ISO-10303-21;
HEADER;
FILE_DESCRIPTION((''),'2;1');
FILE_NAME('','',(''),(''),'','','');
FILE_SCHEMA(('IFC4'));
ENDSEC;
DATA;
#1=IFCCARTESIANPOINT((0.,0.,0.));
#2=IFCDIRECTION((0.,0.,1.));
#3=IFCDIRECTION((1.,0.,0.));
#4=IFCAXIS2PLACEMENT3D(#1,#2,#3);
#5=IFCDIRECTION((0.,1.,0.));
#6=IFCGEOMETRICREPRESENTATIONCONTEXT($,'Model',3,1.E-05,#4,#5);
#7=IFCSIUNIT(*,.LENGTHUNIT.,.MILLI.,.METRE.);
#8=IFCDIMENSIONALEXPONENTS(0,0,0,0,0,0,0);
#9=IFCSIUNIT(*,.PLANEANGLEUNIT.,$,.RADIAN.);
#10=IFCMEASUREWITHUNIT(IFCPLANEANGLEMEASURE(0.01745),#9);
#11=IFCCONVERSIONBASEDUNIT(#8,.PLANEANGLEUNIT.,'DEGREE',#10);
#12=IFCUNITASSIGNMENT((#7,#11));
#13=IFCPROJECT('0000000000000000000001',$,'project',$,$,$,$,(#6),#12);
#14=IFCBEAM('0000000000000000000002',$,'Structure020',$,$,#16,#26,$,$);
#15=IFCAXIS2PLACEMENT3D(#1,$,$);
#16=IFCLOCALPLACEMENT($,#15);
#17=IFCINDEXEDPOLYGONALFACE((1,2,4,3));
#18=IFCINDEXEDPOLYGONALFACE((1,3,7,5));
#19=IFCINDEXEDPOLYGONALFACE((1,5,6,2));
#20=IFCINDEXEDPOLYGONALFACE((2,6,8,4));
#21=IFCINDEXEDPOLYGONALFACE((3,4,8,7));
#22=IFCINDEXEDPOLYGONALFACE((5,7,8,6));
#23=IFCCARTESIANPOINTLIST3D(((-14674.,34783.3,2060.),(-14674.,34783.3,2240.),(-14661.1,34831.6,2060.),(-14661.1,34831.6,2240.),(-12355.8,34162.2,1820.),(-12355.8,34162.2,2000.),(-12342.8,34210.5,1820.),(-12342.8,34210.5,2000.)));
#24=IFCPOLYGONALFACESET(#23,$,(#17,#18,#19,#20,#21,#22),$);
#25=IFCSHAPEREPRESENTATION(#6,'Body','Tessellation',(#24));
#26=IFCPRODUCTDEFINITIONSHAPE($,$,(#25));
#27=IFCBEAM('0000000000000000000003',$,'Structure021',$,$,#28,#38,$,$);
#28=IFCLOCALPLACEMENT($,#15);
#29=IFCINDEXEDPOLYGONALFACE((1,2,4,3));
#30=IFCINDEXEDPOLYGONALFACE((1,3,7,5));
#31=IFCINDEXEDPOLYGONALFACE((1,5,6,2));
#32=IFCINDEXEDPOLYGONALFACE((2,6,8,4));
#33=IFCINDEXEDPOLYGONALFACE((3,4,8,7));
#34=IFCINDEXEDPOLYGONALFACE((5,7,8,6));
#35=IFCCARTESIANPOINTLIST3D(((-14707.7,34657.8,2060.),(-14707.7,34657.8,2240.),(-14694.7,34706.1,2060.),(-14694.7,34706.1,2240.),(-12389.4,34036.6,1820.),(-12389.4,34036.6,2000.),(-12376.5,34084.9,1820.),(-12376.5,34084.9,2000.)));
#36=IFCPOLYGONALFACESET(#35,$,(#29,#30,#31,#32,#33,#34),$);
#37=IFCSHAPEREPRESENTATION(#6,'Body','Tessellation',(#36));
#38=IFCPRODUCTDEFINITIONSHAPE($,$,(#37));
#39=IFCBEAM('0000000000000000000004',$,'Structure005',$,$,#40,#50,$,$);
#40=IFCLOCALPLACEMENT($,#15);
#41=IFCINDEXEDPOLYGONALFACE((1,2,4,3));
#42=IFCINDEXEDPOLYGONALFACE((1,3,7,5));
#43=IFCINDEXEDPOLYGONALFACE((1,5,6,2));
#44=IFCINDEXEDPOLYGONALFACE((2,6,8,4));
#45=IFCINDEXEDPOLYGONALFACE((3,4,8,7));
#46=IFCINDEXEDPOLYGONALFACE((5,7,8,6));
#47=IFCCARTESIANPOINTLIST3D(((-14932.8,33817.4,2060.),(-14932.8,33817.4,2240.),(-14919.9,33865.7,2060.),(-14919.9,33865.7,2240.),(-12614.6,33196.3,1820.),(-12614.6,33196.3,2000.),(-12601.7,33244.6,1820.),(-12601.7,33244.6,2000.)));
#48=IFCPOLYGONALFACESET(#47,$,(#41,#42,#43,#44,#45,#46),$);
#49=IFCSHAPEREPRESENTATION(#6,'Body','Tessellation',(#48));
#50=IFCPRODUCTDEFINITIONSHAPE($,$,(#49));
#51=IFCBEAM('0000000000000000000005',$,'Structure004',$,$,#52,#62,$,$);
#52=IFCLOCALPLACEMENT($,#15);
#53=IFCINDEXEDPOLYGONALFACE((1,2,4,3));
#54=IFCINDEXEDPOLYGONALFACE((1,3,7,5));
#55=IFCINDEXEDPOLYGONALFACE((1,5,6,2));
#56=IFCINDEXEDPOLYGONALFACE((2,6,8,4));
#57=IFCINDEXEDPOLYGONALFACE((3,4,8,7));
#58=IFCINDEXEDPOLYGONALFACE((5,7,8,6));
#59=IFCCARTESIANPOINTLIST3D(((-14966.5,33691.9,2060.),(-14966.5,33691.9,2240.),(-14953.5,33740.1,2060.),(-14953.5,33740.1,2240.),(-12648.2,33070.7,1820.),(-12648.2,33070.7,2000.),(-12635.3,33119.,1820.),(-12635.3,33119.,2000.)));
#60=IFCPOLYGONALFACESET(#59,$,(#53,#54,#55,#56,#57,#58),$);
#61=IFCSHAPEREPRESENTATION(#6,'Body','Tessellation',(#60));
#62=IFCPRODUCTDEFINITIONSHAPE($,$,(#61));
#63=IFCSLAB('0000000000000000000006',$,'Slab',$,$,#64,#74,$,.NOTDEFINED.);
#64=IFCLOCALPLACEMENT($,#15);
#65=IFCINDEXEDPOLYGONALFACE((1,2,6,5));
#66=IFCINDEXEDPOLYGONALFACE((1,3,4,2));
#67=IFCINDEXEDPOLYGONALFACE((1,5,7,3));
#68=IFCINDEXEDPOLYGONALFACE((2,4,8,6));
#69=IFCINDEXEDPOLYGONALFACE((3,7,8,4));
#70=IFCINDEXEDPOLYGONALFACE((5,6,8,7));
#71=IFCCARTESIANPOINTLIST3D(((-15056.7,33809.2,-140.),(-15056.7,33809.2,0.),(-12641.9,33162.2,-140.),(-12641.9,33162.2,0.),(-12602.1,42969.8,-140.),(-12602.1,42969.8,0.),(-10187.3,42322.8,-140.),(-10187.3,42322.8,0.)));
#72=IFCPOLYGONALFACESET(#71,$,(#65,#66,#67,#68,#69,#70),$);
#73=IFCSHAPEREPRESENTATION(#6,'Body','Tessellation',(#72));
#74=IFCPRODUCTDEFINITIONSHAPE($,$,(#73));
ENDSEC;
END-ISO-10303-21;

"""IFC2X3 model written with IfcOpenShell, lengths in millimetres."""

from ifc_helpers import new_model, entity, si_unit, converted_unit, direction, frame, origin_with_axes, place, context, project, polyline, outline, extrude, element, save


model = new_model("IFC2X3")

# Units and contexts
model_context = context("Model", 3, precision=1e-05, world=origin_with_axes(), true_north=direction((0.0, 1.0, 0.0)))
ifc_project = project(units=[si_unit("LENGTHUNIT", "METRE", prefix="MILLI"), converted_unit("PLANEANGLEUNIT", "DEGREE", entity("IfcPlaneAngleMeasure", 0.01745), si_unit("PLANEANGLEUNIT", "RADIAN"), dimensions=[0, 0, 0, 0, 0, 0, 0])], contexts=[model_context])

# Beams
beam_1_placement = place(None, origin_with_axes())
element("IfcBeam", 1, at=beam_1_placement, Name="Structure020", context=model_context, shape_type="SweptSolid", body=[
    extrude(outline(polyline([(-90.0, -25.0), (90.0, -25.0), (90.0, 25.0), (-90.0, 25.0), (-90.0, -25.0)])), frame((-14667.5, 34807.5, 2150.0), z_axis=(0.965926, -0.258818, 0.0), x_axis=(0.0, 0.0, -1.0)), (0.099504, 0.0, 0.995037), 2412.0),
])
beam_2_placement = place(None, origin_with_axes())
element("IfcBeam", 2, at=beam_2_placement, Name="Structure021", context=model_context, shape_type="SweptSolid", body=[
    extrude(outline(polyline([(-90.0, -25.0), (90.0, -25.0), (90.0, 25.0), (-90.0, 25.0), (-90.0, -25.0)])), frame((-14701.2, 34681.9, 2150.0), z_axis=(0.965926, -0.258818, 0.0), x_axis=(0.0, 0.0, -1.0)), (0.099504, 0.0, 0.995037), 2412.0),
])
beam_3_placement = place(None, origin_with_axes())
element("IfcBeam", 3, at=beam_3_placement, Name="Structure005", context=model_context, shape_type="SweptSolid", body=[
    extrude(outline(polyline([(-90.0, -25.0), (90.0, -25.0), (90.0, 25.0), (-90.0, 25.0), (-90.0, -25.0)])), frame((-14926.4, 33841.6, 2150.0), z_axis=(0.965926, -0.258818, 0.0), x_axis=(0.0, 0.0, -1.0)), (0.099504, 0.0, 0.995037), 2412.0),
])
beam_4_placement = place(None, origin_with_axes())
element("IfcBeam", 4, at=beam_4_placement, Name="Structure004", context=model_context, shape_type="SweptSolid", body=[
    extrude(outline(polyline([(-90.0, -25.0), (90.0, -25.0), (90.0, 25.0), (-90.0, 25.0), (-90.0, -25.0)])), frame((-14960.0, 33716.0, 2150.0), z_axis=(0.965926, -0.258818, 0.0), x_axis=(0.0, 0.0, -1.0)), (0.099504, 0.0, 0.995037), 2412.0),
])

# Slab
slab_placement = place(None, origin_with_axes())
element("IfcSlab", 5, at=slab_placement, Name="Slab", PredefinedType="NOTDEFINED", context=model_context, shape_type="SweptSolid", body=[
    extrude(outline(polyline([(0.0, 0.0), (-2500.0, 0.0), (-2500.0, -9483.7), (0.0, -9483.7), (0.0, 0.0)])), frame((-15056.7, 33809.2, -140.0), z_axis=(0.0, 0.0, 1.0), x_axis=(-0.965926, 0.258819, 0.0)), (0.0, 0.0, 1.0), 140.0),
])

save(model, "model.ifc")
